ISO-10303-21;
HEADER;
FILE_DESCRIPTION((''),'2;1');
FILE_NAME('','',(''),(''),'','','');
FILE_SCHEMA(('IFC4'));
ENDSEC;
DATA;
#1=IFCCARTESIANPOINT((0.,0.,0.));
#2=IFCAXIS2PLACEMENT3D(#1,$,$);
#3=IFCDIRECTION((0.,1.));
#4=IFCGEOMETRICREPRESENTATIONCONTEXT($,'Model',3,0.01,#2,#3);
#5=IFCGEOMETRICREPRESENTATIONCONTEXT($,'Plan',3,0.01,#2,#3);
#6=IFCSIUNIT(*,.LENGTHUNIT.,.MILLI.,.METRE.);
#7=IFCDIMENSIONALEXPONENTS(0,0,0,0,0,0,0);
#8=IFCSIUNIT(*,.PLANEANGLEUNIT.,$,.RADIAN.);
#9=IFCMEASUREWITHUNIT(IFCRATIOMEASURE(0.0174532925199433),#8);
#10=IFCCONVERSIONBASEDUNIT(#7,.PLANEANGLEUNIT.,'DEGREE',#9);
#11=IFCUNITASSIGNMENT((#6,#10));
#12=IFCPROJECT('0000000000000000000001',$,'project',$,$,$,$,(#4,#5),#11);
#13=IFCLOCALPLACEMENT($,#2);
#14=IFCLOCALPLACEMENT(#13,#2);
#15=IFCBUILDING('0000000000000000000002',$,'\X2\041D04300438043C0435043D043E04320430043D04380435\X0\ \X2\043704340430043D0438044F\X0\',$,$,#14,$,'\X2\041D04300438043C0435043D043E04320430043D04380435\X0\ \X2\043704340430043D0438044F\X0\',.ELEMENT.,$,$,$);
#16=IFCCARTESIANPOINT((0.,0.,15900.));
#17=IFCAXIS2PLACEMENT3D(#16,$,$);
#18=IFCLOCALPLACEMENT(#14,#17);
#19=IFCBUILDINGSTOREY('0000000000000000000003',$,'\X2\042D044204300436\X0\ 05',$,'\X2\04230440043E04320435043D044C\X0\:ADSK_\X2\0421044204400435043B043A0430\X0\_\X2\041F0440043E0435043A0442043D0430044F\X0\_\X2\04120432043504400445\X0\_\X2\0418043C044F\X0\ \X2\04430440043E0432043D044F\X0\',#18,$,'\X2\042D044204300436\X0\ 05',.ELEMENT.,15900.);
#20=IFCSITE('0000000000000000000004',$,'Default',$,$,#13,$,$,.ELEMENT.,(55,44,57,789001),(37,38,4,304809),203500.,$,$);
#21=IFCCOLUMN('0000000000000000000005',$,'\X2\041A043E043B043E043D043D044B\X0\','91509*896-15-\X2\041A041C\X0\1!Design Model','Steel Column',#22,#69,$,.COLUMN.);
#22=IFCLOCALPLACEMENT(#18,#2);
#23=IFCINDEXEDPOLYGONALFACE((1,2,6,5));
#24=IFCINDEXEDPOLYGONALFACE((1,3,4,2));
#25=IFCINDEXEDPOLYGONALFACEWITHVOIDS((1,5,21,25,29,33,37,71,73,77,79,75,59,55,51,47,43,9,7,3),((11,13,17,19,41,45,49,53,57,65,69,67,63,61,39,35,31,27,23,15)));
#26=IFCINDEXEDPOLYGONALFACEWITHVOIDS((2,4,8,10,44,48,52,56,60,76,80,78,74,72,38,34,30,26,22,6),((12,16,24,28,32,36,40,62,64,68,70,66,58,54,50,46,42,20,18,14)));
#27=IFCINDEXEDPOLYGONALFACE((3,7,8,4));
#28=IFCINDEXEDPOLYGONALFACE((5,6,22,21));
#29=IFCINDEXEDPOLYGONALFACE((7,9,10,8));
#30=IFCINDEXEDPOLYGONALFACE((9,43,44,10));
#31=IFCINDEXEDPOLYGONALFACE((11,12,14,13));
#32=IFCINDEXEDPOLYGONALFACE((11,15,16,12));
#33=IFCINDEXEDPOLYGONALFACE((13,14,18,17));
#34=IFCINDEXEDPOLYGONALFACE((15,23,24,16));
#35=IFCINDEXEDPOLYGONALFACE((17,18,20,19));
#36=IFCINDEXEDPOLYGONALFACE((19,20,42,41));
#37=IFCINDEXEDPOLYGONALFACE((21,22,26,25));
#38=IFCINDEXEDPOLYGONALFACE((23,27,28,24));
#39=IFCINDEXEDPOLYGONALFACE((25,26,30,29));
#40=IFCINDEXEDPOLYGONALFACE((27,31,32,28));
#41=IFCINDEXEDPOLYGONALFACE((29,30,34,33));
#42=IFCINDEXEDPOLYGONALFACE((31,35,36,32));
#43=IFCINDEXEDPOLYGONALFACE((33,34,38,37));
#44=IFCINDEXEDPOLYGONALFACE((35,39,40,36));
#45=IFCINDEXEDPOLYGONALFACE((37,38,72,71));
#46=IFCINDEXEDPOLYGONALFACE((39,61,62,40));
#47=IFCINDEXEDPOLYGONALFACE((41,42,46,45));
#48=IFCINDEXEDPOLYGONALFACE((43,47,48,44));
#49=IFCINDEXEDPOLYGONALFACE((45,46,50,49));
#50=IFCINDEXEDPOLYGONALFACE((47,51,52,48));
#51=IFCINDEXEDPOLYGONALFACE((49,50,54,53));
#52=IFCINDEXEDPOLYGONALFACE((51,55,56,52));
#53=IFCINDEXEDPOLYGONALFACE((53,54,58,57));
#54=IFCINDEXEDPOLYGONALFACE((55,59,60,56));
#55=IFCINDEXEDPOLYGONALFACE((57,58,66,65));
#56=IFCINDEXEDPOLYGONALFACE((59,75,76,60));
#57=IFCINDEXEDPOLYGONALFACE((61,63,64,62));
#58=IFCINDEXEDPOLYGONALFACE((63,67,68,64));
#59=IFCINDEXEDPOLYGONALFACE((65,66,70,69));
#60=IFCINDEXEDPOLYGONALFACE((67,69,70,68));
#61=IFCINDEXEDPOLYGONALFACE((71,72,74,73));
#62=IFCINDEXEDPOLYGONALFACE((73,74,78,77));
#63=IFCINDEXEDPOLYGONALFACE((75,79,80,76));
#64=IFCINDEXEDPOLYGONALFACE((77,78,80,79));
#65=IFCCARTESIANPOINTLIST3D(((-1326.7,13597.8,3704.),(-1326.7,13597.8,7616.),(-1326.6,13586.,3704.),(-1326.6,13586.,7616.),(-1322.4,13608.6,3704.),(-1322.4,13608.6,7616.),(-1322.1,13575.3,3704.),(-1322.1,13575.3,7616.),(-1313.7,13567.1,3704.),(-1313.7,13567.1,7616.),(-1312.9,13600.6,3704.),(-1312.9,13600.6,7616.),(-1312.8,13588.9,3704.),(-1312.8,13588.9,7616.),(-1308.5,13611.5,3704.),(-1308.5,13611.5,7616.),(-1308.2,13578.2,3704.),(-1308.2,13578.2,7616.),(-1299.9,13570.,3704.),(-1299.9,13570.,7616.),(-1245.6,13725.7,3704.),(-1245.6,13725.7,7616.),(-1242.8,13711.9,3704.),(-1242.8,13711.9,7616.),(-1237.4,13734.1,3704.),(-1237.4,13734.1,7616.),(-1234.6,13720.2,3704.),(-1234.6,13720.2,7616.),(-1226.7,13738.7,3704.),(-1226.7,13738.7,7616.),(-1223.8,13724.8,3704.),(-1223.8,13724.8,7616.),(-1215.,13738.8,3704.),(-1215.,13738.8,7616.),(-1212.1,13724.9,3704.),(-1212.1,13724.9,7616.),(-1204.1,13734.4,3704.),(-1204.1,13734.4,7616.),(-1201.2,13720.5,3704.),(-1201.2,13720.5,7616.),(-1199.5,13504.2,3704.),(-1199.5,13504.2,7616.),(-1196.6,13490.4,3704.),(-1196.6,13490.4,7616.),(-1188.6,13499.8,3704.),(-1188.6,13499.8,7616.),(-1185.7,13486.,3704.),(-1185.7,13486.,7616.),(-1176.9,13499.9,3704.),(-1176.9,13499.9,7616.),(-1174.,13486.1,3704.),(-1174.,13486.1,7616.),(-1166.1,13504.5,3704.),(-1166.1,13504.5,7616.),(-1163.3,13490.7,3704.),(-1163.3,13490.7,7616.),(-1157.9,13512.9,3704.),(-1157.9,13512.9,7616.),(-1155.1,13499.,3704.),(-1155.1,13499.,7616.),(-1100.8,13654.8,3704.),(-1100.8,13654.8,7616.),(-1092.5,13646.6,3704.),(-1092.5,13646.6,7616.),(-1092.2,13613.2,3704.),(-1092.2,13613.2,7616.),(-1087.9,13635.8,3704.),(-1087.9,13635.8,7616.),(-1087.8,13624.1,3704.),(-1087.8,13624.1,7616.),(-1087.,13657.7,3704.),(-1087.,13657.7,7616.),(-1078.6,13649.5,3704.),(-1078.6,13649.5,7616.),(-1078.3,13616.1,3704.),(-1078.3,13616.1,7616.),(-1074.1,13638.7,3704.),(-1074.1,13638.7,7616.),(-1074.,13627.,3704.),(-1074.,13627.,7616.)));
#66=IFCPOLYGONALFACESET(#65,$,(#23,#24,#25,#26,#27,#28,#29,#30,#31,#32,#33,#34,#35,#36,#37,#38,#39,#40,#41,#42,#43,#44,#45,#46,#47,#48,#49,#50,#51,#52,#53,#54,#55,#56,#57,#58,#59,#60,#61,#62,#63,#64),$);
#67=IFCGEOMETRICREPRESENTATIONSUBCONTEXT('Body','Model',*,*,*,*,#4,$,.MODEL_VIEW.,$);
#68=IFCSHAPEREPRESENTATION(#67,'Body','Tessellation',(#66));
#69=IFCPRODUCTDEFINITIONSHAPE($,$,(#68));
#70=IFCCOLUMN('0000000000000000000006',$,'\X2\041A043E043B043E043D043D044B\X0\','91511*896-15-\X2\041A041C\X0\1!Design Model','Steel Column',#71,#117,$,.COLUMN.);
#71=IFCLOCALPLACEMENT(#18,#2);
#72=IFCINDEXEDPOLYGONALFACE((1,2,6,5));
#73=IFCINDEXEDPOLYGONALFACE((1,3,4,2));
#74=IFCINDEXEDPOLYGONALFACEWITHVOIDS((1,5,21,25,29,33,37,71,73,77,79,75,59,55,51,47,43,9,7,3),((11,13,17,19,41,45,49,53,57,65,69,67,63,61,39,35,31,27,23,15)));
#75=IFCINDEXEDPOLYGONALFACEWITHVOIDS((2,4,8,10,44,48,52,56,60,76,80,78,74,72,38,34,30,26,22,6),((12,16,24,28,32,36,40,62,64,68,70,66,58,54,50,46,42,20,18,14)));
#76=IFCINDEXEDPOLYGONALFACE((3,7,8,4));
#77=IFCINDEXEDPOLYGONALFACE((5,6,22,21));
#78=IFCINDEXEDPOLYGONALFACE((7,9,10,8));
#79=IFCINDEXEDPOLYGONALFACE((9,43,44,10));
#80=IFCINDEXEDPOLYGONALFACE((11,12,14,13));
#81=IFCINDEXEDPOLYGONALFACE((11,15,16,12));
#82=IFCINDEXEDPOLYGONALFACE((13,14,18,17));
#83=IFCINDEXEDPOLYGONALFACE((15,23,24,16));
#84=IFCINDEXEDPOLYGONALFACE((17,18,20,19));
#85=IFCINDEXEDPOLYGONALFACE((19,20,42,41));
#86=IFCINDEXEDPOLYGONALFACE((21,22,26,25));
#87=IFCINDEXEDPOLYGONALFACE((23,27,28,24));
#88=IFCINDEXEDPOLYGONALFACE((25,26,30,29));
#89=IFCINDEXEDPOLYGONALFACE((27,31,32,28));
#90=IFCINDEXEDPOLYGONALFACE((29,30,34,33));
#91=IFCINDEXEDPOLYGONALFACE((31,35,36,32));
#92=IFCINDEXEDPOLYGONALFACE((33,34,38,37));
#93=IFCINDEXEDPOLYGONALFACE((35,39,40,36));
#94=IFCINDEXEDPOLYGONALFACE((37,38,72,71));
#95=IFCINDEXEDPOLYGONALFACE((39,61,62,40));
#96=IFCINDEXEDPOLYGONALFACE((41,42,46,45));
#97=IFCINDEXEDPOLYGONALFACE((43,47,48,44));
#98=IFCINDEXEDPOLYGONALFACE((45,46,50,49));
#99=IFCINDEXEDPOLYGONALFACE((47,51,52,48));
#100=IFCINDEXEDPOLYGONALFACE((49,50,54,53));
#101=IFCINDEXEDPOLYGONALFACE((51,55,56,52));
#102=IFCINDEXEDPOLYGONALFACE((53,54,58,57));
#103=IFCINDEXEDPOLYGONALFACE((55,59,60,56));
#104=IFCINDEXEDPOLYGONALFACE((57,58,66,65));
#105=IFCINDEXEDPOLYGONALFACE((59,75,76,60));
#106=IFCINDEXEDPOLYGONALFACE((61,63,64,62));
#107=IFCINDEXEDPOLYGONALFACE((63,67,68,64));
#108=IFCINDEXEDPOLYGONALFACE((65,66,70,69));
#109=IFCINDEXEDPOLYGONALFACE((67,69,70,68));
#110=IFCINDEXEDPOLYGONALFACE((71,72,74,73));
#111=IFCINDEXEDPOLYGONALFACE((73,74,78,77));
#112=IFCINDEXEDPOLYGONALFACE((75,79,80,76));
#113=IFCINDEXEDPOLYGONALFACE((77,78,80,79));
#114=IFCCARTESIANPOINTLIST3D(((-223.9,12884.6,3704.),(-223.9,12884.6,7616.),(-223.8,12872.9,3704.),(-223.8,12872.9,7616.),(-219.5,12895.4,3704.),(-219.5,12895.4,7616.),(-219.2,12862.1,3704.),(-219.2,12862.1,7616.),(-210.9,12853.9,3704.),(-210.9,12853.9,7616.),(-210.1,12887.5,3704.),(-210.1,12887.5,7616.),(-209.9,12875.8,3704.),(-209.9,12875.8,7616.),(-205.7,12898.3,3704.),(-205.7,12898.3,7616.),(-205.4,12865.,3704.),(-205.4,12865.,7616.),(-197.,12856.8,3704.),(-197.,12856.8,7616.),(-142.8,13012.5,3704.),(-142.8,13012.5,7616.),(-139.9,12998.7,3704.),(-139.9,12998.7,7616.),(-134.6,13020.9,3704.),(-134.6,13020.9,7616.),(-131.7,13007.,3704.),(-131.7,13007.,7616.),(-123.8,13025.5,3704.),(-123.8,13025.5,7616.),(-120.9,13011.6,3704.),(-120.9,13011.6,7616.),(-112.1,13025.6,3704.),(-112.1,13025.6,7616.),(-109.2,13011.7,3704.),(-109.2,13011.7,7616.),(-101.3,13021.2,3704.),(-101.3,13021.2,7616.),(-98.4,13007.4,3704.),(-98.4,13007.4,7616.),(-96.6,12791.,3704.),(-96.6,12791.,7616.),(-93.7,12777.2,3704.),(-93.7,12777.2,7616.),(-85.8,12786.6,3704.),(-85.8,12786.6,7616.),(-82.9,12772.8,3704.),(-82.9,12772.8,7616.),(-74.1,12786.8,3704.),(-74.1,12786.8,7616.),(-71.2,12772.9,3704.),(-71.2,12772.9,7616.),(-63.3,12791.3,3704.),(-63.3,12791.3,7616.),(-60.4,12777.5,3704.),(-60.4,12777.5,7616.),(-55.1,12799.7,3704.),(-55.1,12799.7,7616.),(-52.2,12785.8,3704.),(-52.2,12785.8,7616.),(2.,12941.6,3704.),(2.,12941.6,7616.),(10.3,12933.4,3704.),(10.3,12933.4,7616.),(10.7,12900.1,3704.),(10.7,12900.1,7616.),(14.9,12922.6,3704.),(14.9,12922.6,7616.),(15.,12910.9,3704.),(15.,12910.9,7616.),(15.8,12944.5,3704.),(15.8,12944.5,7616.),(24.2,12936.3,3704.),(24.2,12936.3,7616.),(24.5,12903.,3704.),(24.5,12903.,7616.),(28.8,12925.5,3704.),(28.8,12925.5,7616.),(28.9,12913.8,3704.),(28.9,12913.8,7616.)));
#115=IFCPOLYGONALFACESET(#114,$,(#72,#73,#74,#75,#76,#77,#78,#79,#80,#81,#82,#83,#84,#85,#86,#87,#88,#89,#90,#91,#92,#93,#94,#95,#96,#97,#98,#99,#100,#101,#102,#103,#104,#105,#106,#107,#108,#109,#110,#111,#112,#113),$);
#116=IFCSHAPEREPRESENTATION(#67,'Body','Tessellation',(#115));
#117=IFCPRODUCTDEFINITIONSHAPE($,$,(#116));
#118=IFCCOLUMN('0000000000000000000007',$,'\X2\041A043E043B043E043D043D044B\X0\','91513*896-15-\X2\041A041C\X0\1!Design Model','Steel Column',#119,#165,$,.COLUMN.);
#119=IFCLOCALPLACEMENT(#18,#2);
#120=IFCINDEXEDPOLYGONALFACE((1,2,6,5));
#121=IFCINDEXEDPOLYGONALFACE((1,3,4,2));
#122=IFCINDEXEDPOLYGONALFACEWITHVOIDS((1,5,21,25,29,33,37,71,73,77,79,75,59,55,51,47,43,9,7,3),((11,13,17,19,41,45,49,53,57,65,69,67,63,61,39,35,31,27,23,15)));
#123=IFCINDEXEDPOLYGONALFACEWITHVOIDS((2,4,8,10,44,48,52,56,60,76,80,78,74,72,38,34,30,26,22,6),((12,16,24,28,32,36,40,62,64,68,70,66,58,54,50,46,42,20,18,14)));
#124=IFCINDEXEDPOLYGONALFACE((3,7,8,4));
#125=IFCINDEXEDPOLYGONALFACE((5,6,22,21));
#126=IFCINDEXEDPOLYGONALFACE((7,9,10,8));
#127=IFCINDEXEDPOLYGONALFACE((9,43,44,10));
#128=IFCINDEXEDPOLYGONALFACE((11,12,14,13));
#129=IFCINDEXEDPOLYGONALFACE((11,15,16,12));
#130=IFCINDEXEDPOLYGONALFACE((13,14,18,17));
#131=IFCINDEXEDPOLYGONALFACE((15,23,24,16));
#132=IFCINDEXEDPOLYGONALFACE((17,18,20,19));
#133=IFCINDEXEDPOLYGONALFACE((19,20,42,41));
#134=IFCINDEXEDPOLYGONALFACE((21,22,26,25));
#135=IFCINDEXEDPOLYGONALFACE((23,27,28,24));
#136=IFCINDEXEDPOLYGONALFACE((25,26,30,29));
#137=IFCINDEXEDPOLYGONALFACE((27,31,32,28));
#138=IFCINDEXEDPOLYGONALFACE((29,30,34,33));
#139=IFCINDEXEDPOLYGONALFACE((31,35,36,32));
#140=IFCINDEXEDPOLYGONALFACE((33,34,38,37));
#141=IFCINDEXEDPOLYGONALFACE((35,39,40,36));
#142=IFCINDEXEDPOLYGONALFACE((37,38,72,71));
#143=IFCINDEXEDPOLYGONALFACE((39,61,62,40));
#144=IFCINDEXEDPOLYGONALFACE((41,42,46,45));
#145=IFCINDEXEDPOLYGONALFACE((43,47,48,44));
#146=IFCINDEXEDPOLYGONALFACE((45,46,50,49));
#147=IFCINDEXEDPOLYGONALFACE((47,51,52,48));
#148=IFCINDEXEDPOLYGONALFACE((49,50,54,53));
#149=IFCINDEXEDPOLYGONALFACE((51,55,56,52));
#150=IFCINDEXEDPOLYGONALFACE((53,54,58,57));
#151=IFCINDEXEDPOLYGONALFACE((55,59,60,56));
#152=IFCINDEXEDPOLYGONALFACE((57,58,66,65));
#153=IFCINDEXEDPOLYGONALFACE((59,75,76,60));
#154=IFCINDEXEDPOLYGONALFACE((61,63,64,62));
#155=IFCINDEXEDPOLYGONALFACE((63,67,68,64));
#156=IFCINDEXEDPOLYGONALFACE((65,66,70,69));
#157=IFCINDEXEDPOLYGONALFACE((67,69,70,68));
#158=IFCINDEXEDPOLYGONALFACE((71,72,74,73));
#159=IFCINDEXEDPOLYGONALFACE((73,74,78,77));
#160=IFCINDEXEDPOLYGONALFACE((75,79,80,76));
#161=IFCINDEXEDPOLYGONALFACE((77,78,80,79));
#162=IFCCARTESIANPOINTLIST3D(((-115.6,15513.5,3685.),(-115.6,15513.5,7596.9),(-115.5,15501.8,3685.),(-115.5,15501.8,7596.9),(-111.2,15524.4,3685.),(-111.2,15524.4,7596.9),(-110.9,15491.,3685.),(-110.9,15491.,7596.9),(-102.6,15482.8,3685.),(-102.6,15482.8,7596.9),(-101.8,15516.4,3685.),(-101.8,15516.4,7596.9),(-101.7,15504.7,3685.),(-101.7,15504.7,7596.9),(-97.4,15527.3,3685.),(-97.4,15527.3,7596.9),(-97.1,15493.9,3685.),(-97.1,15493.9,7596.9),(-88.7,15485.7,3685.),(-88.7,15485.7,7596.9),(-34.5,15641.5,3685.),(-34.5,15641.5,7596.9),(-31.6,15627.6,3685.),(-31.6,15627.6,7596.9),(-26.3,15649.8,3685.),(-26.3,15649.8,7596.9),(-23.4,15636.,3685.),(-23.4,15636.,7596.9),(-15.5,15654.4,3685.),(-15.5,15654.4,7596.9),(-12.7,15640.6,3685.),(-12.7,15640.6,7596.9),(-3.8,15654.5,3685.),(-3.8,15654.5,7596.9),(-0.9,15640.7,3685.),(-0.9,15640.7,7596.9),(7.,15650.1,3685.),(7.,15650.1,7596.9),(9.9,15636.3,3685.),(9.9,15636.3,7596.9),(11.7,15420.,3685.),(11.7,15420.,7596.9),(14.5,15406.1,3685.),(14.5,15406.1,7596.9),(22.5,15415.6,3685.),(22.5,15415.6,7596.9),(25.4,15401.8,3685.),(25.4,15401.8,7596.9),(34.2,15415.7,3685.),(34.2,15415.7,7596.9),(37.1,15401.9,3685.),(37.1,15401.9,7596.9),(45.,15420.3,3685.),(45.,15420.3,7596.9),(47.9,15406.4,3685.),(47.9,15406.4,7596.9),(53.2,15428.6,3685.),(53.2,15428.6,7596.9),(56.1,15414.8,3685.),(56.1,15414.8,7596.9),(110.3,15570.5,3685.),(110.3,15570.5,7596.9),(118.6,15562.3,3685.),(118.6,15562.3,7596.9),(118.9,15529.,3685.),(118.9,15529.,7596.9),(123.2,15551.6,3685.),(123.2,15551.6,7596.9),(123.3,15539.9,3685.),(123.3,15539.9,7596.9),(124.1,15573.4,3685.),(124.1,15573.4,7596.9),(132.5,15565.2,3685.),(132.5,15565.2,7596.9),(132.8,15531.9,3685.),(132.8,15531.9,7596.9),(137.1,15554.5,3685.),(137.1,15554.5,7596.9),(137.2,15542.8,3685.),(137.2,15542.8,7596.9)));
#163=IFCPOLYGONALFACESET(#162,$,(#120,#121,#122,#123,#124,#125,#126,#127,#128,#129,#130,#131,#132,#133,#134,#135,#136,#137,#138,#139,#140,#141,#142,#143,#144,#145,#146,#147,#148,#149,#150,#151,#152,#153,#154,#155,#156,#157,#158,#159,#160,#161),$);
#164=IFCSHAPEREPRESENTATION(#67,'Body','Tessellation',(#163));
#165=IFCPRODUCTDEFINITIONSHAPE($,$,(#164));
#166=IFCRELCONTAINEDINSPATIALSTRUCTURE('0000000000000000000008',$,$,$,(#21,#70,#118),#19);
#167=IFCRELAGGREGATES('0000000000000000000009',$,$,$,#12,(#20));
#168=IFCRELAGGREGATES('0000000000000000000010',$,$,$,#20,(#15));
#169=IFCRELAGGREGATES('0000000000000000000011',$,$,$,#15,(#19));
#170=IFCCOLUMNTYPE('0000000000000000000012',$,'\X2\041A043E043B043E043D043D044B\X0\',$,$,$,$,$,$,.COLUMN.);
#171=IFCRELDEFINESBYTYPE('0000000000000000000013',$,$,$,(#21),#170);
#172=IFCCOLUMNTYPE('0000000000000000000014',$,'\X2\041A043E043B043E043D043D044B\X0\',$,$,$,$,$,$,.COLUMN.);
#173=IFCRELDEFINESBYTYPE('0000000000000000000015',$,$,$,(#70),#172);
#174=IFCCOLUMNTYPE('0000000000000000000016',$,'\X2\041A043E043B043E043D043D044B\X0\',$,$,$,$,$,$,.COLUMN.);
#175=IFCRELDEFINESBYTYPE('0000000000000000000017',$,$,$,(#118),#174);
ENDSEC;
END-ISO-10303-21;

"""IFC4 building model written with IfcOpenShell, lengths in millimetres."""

from ifc_helpers import new_model, entity, si_unit, converted_unit, direction, frame, origin, place, context, subcontext, project, spatial, indexed_curve, outline, extrude, type_object, element, save


model = new_model("IFC4")

# Units and contexts
model_context = context("Model", 3, precision=0.01, world=origin(), true_north=direction((0.0, 1.0)))
plan_context = context("Plan", 3, precision=0.01, world=origin(), true_north=direction((0.0, 1.0)))
body_context = subcontext(model_context, "Body", "Model", "MODEL_VIEW")
ifc_project = project(units=[si_unit("LENGTHUNIT", "METRE", prefix="MILLI"), converted_unit("PLANEANGLEUNIT", "DEGREE", entity("IfcRatioMeasure", 0.0174532925199433), si_unit("PLANEANGLEUNIT", "RADIAN"), dimensions=[0, 0, 0, 0, 0, 0, 0])], contexts=[model_context, plan_context])

# Site, building, storey
site_placement = place(None, origin())
site = spatial("IfcSite", under=ifc_project, at=site_placement, Name="Default", CompositionType="ELEMENT", RefLatitude=(55, 44, 57, 789001), RefLongitude=(37, 38, 4, 304809), RefElevation=203500.0)
building_placement = place(site_placement, origin())
building = spatial("IfcBuilding", under=site, at=building_placement, Name="Наименование здания", LongName="Наименование здания", CompositionType="ELEMENT")
storey_placement = place(building_placement, frame((0.0, 0.0, 15900.0)))
storey = spatial("IfcBuildingStorey", under=building, at=storey_placement, Name="Этаж 05", ObjectType="Уровень:ADSK_Стрелка_Проектная_Вверх_Имя уровня", LongName="Этаж 05", CompositionType="ELEMENT", Elevation=15900.0)

# Columns
placement = place(storey_placement, origin())
column_type_1 = type_object("IfcColumnType", Name="Колонны", PredefinedType="COLUMN")
element("IfcColumn", 1, at=placement, inside=storey, type_object=column_type_1, Name="Колонны", Description="91509*896-15-КМ1!Design Model", ObjectType="Steel Column", PredefinedType="COLUMN", context=body_context, shape_type="SweptSolid", body=[
    extrude(outline(indexed_curve([(49.1, -111.7), (60.9, -111.7), (71.7, -107.3), (79.9, -99.0), (84.4, -88.2), (111.7, 49.1), (111.7, 60.9), (107.3, 71.7), (99.0, 79.9), (88.2, 84.4), (-49.1, 111.7), (-60.9, 111.7), (-71.7, 107.3), (-79.9, 99.0), (-84.4, 88.2), (-111.7, -49.1), (-111.7, -60.9), (-107.3, -71.7), (-99.0, -79.9), (-88.2, -84.4), (49.1, -111.7)], self_intersect=False), holes=[indexed_curve([(-76.4, -76.6), (-87.2, -72.1), (-95.5, -63.8), (-100.0, -53.0), (-100.0, -41.3), (-76.6, 76.4), (-72.1, 87.2), (-63.8, 95.5), (-53.0, 100.0), (-41.3, 100.0), (76.4, 76.6), (87.2, 72.1), (95.5, 63.8), (100.0, 53.0), (100.0, 41.3), (76.6, -76.4), (72.1, -87.2), (63.8, -95.5), (53.0, -100.0), (41.3, -100.0), (-76.4, -76.6)], self_intersect=False)]), frame((-1200.3, 13612.4, 3704.1), z_axis=(0.0, 0.0, 1.0), x_axis=(0.927337, -0.374228, 0.0)), (0.0, 0.0, 1.0), 3911.9),
])
column_type_2 = type_object("IfcColumnType", Name="Колонны", PredefinedType="COLUMN")
element("IfcColumn", 2, at=placement, inside=storey, type_object=column_type_2, Name="Колонны", Description="91511*896-15-КМ1!Design Model", ObjectType="Steel Column", PredefinedType="COLUMN", context=body_context, shape_type="SweptSolid", body=[
    extrude(outline(indexed_curve([(49.1, -111.7), (60.9, -111.7), (71.7, -107.3), (79.9, -99.0), (84.4, -88.2), (111.7, 49.1), (111.7, 60.9), (107.3, 71.7), (99.0, 79.9), (88.2, 84.4), (-49.1, 111.7), (-60.9, 111.7), (-71.7, 107.3), (-79.9, 99.0), (-84.4, 88.2), (-111.7, -49.1), (-111.7, -60.9), (-107.3, -71.7), (-99.0, -79.9), (-88.2, -84.4), (49.1, -111.7)], self_intersect=False), holes=[indexed_curve([(-76.4, -76.6), (-87.2, -72.1), (-95.5, -63.8), (-100.0, -53.0), (-100.0, -41.3), (-76.6, 76.4), (-72.1, 87.2), (-63.8, 95.5), (-53.0, 100.0), (-41.3, 100.0), (76.4, 76.6), (87.2, 72.1), (95.5, 63.8), (100.0, 53.0), (100.0, 41.3), (76.6, -76.4), (72.1, -87.2), (63.8, -95.5), (53.0, -100.0), (41.3, -100.0), (-76.4, -76.6)], self_intersect=False)]), frame((-97.5, 12899.2, 3704.1), z_axis=(0.0, 0.0, 1.0), x_axis=(0.927337, -0.374228, 0.0)), (0.0, 0.0, 1.0), 3911.9),
])
column_type_3 = type_object("IfcColumnType", Name="Колонны", PredefinedType="COLUMN")
element("IfcColumn", 3, at=placement, inside=storey, type_object=column_type_3, Name="Колонны", Description="91513*896-15-КМ1!Design Model", ObjectType="Steel Column", PredefinedType="COLUMN", context=body_context, shape_type="SweptSolid", body=[
    extrude(outline(indexed_curve([(49.1, -111.7), (60.9, -111.7), (71.7, -107.3), (79.9, -99.0), (84.4, -88.2), (111.7, 49.1), (111.7, 60.9), (107.3, 71.7), (99.0, 79.9), (88.2, 84.4), (-49.1, 111.7), (-60.9, 111.7), (-71.7, 107.3), (-79.9, 99.0), (-84.4, 88.2), (-111.7, -49.1), (-111.7, -60.9), (-107.3, -71.7), (-99.0, -79.9), (-88.2, -84.4), (49.1, -111.7)], self_intersect=False), holes=[indexed_curve([(-76.4, -76.6), (-87.2, -72.1), (-95.5, -63.8), (-100.0, -53.0), (-100.0, -41.3), (-76.6, 76.4), (-72.1, 87.2), (-63.8, 95.5), (-53.0, 100.0), (-41.3, 100.0), (76.4, 76.6), (87.2, 72.1), (95.5, 63.8), (100.0, 53.0), (100.0, 41.3), (76.6, -76.4), (72.1, -87.2), (63.8, -95.5), (53.0, -100.0), (41.3, -100.0), (-76.4, -76.6)], self_intersect=False)]), frame((10.8, 15528.1, 3685.0), z_axis=(0.0, 0.0, 1.0), x_axis=(0.927337, -0.374228, 0.0)), (0.0, 0.0, 1.0), 3911.9),
])

save(model, "model.ifc")
